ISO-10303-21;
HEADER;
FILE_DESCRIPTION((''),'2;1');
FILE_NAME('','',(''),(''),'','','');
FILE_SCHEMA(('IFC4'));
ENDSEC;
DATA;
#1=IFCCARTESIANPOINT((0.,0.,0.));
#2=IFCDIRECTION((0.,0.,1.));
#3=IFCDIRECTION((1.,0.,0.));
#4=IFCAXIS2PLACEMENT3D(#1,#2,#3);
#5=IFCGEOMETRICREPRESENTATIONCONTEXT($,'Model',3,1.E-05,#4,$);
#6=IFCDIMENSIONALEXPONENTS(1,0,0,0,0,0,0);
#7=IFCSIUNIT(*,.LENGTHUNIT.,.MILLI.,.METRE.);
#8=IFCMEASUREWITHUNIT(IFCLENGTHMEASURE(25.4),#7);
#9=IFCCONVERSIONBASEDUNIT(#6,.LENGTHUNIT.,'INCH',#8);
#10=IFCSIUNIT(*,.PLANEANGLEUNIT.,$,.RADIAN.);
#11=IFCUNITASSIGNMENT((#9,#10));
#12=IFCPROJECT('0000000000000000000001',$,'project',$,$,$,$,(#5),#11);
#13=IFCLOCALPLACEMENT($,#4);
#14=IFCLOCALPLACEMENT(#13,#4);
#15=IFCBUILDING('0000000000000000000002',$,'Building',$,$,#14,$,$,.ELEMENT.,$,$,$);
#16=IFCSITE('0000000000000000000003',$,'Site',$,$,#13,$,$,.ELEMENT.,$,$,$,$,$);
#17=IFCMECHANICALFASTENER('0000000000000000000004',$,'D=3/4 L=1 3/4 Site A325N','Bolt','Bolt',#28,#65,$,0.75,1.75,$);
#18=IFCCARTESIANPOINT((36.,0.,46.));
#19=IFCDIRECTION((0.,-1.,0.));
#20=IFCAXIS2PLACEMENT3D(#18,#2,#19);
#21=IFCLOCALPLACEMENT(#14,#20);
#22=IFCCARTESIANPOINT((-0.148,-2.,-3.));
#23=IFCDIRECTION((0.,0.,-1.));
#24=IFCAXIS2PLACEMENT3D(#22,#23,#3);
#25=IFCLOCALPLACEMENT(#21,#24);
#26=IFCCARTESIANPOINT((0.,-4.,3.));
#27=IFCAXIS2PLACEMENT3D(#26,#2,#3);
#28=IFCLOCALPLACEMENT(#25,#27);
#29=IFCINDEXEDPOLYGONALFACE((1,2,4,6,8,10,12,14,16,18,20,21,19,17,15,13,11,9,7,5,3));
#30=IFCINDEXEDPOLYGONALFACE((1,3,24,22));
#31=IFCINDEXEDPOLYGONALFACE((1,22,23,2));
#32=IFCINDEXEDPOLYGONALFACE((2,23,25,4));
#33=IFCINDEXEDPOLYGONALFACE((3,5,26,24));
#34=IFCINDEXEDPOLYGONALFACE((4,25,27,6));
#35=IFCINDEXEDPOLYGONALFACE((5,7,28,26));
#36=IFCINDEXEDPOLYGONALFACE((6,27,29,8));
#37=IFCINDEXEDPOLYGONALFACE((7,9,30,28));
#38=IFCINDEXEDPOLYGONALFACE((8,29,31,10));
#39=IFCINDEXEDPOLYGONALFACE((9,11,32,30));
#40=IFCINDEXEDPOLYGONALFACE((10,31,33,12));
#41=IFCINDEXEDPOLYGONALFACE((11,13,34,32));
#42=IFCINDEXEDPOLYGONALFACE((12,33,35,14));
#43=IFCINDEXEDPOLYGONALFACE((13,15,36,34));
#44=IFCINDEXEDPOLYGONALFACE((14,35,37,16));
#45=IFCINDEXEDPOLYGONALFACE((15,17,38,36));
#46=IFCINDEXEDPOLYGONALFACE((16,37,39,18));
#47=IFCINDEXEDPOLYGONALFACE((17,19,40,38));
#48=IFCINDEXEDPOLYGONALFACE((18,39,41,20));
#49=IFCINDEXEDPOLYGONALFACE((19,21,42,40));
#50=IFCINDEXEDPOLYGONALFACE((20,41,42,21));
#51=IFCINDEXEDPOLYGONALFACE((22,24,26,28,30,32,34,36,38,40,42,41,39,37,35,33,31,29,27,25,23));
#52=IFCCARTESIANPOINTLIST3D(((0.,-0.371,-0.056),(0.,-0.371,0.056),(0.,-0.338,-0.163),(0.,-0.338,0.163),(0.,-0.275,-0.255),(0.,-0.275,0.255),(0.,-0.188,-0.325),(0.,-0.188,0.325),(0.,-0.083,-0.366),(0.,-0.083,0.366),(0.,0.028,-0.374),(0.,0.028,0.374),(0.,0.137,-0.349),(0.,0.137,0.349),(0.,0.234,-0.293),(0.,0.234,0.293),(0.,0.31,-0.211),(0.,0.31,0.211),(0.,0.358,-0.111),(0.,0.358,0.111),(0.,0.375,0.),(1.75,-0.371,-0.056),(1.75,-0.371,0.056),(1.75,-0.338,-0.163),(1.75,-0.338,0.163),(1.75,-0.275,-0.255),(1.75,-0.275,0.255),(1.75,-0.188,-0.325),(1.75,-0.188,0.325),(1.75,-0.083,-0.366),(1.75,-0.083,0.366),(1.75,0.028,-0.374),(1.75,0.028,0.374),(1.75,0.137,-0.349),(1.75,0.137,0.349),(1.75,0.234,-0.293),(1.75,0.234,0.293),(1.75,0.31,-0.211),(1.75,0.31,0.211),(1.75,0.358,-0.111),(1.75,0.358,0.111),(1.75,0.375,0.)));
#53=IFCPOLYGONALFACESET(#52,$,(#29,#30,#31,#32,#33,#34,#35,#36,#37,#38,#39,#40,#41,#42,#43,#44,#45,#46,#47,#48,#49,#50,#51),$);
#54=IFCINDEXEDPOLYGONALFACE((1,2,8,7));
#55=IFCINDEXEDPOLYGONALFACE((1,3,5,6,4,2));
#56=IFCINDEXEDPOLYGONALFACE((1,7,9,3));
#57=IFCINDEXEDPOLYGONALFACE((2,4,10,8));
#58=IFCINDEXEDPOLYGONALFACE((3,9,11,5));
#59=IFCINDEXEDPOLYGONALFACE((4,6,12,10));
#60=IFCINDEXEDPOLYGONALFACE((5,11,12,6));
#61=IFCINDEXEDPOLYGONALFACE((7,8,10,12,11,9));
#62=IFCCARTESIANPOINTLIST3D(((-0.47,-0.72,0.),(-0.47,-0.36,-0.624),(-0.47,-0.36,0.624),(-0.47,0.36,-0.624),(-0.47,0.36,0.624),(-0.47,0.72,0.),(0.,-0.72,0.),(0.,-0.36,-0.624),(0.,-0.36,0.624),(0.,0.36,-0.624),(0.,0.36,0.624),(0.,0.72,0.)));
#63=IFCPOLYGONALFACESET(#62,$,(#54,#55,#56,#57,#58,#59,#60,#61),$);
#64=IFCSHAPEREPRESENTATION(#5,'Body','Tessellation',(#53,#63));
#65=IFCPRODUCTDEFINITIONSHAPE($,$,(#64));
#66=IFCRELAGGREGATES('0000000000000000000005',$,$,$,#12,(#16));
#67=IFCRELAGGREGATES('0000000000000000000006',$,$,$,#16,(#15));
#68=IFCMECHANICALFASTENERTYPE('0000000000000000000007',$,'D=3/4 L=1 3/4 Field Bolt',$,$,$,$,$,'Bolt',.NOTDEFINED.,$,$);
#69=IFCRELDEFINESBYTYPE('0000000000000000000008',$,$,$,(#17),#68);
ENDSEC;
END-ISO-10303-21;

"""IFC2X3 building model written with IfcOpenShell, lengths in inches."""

from ifc_helpers import new_model, entity, si_unit, converted_unit, frame, origin_with_axes, origin_2d_with_axis, place, context, project, spatial, polyline, circle, outline, extrude, source, transform, mapped, type_object, type_shapes, element, save


model = new_model("IFC2X3")

# Units and contexts
model_context = context("Model", 3, precision=1e-05, world=origin_with_axes())
ifc_project = project(units=[converted_unit("LENGTHUNIT", "INCH", entity("IfcLengthMeasure", 25.4), si_unit("LENGTHUNIT", "METRE", prefix="MILLI"), dimensions=[1, 0, 0, 0, 0, 0, 0]), si_unit("PLANEANGLEUNIT", "RADIAN")], contexts=[model_context])

# Site, building
site_placement = place(None, origin_with_axes())
site = spatial("IfcSite", under=ifc_project, at=site_placement, Name="Site", CompositionType="ELEMENT")
building_placement = place(site_placement, origin_with_axes())
building = spatial("IfcBuilding", under=site, at=building_placement, Name="Building", CompositionType="ELEMENT")

# Mechanical fastener
mechanical_fastener_type_1 = type_object("IfcMechanicalFastenerType", Name="D=3/4 L=1 3/4 Field Bolt", ElementType="Bolt")
shared_shape_1 = source(origin_with_axes(), model_context, "Body", "SweptSolid", [
    extrude(circle(Radius=0.375, at=origin_2d_with_axis()), frame((0.0, 0.0, 0.0), z_axis=(1.0, 0.0, 0.0), x_axis=(0.0, 1.0, 0.0)), (0.0, 0.0, 1.0), 1.75),
    extrude(outline(polyline([(-0.72, 0.0), (-0.36, 0.624), (0.36, 0.624), (0.72, 0.0), (0.36, -0.624), (-0.36, -0.624), (-0.72, 0.0)])), frame((0.0, 0.0, 0.0), z_axis=(1.0, 0.0, 0.0), x_axis=(0.0, 1.0, 0.0)), (0.0, 0.0, -1.0), 0.47),
])
type_shapes(mechanical_fastener_type_1, [shared_shape_1])
placement_1 = place(building_placement, frame((36.0, 0.0, 46.0), z_axis=(0.0, 0.0, 1.0), x_axis=(0.0, -1.0, 0.0)))
placement_2 = place(placement_1, frame((-0.148, -2.0, -3.0), z_axis=(0.0, 0.0, -1.0), x_axis=(1.0, 0.0, 0.0)))
for number, where, z_axis, x_axis, name in (
    (1, (0.0, -4.0, 3.0), (0.0, 0.0, 1.0), (1.0, 0.0, 0.0), "D=3/4 L=1 3/4 Site A325N"),
):
    element("IfcMechanicalFastener", number, at=place(placement_2, frame(where, z_axis=z_axis, x_axis=x_axis)), type_object=mechanical_fastener_type_1, Name=name, Description="Bolt", ObjectType="Bolt", NominalDiameter=0.75, NominalLength=1.75, context=model_context, shape_type="MappedRepresentation", body=[
        mapped(shared_shape_1, transform((0.0, 0.0, 0.0), scale=1.0)),
    ])

save(model, "model.ifc")
